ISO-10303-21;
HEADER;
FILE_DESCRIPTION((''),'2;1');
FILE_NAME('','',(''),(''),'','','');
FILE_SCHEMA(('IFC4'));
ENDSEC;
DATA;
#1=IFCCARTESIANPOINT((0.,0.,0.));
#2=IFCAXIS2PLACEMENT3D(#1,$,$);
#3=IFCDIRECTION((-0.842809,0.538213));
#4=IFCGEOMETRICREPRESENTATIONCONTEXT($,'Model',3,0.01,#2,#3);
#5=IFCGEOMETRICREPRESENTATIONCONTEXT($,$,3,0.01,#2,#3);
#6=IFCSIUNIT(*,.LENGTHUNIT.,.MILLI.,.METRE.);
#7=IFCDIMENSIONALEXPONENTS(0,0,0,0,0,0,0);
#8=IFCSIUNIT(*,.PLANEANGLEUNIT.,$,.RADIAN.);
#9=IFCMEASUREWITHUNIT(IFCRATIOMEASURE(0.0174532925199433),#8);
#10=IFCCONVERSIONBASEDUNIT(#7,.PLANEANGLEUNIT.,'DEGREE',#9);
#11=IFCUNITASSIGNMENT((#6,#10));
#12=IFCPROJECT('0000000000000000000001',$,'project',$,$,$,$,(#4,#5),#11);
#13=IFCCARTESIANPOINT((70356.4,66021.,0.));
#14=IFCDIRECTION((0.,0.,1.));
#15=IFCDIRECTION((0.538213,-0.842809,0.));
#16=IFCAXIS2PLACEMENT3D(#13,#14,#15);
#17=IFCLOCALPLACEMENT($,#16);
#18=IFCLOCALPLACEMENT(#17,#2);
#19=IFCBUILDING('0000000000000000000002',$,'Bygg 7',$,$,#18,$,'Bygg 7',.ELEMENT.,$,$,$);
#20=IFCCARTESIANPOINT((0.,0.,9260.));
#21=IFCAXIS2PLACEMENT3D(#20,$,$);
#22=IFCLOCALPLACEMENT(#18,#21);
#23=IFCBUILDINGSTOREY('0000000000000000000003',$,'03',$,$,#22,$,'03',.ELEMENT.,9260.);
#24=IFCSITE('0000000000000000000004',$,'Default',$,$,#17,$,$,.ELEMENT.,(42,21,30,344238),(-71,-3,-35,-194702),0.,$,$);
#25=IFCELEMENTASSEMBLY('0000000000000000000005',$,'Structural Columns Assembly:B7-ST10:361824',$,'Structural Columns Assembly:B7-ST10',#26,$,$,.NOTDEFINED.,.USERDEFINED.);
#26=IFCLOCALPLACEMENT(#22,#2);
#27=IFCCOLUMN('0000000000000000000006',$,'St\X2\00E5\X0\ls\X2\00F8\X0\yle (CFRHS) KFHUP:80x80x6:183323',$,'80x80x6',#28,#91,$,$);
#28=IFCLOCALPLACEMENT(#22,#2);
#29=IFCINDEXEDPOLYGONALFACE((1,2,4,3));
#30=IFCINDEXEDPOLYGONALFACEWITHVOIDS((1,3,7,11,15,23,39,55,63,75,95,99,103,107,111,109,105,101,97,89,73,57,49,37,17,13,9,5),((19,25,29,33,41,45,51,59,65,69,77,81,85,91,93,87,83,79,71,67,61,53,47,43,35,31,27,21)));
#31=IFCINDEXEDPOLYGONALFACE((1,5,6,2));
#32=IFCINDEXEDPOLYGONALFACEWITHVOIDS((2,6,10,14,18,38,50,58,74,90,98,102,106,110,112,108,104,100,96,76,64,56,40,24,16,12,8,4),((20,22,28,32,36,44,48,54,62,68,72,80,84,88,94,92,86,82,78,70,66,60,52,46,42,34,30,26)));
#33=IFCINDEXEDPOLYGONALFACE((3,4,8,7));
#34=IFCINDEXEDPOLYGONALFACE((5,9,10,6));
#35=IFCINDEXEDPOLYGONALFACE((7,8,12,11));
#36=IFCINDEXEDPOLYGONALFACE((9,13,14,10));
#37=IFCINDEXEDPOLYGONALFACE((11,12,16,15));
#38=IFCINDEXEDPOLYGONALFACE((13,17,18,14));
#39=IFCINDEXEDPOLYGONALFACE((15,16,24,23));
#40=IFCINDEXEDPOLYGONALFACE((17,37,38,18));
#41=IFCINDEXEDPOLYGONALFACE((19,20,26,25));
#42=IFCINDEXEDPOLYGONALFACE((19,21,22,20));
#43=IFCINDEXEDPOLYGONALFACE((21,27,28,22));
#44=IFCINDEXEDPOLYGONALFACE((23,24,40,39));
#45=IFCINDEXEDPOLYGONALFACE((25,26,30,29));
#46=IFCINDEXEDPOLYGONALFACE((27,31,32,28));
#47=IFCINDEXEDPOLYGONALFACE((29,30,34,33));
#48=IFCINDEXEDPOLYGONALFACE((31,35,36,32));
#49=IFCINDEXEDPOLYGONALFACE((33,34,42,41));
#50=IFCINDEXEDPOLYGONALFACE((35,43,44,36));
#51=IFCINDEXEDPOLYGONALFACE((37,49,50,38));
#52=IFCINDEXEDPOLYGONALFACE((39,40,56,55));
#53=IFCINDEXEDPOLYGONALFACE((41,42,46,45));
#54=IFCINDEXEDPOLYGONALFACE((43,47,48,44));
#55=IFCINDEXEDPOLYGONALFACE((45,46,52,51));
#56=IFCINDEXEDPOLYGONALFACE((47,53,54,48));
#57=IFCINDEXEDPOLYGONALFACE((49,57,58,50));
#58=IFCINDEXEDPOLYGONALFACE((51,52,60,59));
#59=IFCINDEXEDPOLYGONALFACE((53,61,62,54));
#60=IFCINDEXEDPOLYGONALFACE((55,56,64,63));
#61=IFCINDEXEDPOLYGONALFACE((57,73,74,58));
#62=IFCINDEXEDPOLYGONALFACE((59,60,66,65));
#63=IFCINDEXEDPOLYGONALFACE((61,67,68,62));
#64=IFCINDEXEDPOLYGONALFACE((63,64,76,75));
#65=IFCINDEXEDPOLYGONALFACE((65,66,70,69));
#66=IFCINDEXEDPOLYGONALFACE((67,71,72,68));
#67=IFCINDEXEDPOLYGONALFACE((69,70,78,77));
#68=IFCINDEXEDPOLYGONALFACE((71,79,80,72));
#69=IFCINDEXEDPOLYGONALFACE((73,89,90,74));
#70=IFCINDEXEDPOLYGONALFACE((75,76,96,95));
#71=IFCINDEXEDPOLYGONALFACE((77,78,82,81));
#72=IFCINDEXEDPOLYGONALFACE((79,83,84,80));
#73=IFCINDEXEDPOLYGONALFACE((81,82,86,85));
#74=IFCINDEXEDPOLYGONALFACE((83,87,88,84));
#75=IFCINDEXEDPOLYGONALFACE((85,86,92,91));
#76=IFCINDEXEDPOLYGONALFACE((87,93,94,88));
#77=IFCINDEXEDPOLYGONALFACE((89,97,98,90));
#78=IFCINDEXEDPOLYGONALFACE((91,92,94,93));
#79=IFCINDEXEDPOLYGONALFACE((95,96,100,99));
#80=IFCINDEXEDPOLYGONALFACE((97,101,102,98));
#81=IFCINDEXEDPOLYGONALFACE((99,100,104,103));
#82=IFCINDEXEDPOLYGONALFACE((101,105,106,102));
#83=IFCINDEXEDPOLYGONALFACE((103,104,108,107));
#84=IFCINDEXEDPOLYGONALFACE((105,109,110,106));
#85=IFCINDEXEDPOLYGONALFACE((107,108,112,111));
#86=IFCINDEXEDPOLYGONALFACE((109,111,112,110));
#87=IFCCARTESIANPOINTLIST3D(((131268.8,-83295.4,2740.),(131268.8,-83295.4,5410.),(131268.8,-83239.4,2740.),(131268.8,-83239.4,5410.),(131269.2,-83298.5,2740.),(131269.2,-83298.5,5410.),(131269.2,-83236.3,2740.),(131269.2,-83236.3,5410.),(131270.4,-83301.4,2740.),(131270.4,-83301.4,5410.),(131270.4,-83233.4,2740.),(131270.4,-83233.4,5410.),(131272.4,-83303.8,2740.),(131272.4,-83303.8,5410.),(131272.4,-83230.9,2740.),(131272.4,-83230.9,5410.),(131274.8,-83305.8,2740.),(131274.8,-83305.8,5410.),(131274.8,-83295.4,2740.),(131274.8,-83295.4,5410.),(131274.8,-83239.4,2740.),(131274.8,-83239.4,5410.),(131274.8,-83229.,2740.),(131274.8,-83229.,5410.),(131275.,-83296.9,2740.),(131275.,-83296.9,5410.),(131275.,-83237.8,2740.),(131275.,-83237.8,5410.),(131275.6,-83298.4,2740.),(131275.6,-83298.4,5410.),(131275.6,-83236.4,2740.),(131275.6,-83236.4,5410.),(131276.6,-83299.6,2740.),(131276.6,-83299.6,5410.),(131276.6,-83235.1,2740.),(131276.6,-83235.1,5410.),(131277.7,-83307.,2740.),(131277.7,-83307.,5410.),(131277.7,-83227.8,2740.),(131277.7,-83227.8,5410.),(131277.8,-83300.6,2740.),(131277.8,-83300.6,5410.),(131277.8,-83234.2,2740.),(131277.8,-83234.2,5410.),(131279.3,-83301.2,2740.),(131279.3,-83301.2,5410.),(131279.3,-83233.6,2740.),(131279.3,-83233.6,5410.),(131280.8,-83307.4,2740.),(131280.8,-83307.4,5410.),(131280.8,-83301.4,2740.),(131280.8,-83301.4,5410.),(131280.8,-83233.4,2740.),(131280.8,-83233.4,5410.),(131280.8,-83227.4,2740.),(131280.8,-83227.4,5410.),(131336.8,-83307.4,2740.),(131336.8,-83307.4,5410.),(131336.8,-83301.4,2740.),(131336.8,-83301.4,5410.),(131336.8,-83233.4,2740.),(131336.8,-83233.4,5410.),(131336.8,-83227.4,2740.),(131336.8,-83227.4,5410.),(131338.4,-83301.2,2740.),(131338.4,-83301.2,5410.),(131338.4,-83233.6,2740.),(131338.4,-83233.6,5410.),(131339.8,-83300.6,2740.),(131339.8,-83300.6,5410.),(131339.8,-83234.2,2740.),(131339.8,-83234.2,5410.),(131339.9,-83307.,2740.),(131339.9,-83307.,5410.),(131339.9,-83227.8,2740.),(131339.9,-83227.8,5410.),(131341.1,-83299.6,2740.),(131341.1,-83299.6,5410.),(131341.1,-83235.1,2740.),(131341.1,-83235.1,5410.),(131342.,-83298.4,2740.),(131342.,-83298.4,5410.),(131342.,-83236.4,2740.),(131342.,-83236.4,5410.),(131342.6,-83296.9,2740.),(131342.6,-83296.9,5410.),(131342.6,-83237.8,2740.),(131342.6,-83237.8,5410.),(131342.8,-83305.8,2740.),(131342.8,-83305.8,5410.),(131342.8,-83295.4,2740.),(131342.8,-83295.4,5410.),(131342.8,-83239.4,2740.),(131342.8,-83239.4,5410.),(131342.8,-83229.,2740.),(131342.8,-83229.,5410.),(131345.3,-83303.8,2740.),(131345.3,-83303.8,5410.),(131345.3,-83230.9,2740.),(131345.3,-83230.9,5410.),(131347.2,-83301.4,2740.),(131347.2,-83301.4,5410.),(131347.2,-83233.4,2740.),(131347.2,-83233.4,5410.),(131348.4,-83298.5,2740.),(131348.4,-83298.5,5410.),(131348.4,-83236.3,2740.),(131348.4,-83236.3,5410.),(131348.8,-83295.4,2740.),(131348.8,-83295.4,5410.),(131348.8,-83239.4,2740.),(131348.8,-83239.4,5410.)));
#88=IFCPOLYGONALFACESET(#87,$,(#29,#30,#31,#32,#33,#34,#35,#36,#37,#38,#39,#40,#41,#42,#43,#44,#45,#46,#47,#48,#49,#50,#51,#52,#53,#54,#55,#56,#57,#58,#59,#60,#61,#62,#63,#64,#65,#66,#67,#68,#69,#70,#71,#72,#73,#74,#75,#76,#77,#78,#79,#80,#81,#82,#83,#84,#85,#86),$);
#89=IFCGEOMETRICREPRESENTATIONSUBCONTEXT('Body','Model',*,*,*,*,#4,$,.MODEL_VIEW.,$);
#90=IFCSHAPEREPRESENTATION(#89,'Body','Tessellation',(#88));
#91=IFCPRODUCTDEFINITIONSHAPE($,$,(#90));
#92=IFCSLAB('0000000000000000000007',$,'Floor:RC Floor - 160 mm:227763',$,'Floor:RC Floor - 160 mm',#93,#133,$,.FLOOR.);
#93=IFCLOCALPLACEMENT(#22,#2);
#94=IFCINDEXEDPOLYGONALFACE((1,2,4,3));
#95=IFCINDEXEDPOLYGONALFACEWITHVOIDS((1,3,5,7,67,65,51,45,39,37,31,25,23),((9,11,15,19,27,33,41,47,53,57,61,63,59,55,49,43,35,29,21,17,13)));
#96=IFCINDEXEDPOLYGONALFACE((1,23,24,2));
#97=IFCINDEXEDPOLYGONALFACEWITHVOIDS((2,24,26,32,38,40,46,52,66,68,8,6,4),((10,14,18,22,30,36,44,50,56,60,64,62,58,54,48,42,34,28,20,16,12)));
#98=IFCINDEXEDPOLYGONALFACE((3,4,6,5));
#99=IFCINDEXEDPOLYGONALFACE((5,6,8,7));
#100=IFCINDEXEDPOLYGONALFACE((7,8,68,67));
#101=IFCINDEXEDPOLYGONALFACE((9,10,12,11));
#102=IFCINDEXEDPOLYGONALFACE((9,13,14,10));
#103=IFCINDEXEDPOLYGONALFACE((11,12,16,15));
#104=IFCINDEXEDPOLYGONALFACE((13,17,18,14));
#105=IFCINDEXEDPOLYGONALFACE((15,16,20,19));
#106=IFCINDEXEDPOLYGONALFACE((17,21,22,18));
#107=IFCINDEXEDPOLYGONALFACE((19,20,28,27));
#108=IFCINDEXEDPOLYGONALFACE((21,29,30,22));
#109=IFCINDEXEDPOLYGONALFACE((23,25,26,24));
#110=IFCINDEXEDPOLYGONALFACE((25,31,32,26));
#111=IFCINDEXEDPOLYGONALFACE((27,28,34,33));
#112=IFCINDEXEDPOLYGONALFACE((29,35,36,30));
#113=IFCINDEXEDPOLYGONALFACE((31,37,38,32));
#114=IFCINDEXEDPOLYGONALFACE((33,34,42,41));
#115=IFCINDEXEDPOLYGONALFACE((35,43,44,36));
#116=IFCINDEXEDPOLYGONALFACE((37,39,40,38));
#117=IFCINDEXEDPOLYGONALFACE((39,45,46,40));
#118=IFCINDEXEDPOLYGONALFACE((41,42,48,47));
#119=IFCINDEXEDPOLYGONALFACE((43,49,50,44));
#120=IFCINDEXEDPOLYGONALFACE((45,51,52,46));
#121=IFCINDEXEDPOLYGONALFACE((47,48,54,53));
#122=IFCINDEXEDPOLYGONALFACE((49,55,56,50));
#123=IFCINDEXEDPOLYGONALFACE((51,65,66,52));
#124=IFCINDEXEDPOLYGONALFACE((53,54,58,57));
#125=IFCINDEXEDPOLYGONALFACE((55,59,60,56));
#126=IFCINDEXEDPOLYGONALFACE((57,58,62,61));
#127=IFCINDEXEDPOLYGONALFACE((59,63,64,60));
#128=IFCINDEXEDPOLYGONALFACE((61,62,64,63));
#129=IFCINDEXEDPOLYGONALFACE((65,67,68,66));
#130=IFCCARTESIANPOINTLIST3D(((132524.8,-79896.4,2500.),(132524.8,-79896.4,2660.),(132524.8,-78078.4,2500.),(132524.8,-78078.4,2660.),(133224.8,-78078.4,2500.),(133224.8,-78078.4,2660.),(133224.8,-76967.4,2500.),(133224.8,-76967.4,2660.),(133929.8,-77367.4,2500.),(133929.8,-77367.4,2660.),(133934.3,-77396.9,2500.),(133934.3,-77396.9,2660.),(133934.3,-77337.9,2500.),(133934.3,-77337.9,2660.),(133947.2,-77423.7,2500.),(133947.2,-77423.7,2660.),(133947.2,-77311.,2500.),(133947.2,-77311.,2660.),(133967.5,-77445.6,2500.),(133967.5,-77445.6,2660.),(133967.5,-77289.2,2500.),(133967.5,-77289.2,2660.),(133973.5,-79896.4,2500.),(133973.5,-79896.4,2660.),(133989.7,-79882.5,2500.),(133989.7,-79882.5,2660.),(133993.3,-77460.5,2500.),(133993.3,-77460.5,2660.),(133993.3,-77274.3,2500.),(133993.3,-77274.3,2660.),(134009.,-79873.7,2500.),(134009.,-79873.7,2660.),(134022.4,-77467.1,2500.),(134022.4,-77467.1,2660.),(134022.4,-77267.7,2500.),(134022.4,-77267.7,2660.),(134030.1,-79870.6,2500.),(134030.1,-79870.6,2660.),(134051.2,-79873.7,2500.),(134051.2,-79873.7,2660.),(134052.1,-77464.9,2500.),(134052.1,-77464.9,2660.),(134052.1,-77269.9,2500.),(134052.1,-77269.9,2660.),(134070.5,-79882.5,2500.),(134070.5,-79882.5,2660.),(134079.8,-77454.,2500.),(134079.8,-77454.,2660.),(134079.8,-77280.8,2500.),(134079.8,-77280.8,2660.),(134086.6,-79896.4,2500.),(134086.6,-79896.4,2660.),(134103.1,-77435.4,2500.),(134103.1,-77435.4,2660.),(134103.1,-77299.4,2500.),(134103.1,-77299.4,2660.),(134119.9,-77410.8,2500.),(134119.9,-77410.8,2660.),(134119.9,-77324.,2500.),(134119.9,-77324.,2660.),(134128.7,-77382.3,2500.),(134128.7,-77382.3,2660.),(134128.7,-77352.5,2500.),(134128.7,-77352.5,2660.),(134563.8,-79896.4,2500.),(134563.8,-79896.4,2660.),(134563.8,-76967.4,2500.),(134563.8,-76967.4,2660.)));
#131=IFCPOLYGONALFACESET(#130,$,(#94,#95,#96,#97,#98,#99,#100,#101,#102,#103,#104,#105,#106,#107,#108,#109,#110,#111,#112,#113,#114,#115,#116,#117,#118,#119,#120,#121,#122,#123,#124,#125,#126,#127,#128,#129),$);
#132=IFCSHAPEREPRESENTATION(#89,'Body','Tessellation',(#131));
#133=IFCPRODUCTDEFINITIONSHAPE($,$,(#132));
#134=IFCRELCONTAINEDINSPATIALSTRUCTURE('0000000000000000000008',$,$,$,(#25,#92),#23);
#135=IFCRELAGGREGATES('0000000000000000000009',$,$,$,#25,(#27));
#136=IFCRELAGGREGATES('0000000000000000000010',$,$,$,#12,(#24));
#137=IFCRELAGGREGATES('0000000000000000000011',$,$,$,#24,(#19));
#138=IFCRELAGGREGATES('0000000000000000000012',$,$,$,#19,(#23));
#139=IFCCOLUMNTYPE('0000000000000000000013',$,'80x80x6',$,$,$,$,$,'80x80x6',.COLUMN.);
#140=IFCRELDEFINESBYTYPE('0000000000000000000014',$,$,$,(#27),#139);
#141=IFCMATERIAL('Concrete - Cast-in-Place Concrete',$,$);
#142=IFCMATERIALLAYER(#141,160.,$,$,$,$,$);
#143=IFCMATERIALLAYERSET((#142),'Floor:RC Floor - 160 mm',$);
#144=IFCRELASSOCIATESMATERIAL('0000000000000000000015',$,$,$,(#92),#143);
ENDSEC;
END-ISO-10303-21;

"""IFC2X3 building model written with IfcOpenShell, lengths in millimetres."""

from ifc_helpers import new_model, entity, si_unit, converted_unit, direction, frame, frame_2d, origin, place, context, subcontext, project, spatial, polyline, circle_curve, parameter, trimmed, segment, composite_curve, circle, outline, extrude, source, transform, mapped, material, layer, layer_set, layer_usage, type_object, type_shapes, element, aggregate, save


model = new_model("IFC2X3")

# Units and contexts
model_context = context("Model", 3, precision=0.01, world=origin(), true_north=direction((-0.842809, 0.538213)))
context_of_model = context(None, 3, precision=0.01, world=origin(), true_north=direction((-0.842809, 0.538213)))
body_context = subcontext(model_context, "Body", "Model", "MODEL_VIEW")
ifc_project = project(units=[si_unit("LENGTHUNIT", "METRE", prefix="MILLI"), converted_unit("PLANEANGLEUNIT", "DEGREE", entity("IfcRatioMeasure", 0.0174532925199433), si_unit("PLANEANGLEUNIT", "RADIAN"), dimensions=[0, 0, 0, 0, 0, 0, 0])], contexts=[model_context, context_of_model])

# Site, building, storey
site_placement = place(None, frame((70356.4, 66021.0, 0.0), z_axis=(0.0, 0.0, 1.0), x_axis=(0.538213, -0.842809, 0.0)))
site = spatial("IfcSite", under=ifc_project, at=site_placement, Name="Default", CompositionType="ELEMENT", RefLatitude=(42, 21, 30, 344238), RefLongitude=(-71, -3, -35, -194702), RefElevation=0.0)
building_placement = place(site_placement, origin())
building = spatial("IfcBuilding", under=site, at=building_placement, Name="Bygg 7", LongName="Bygg 7", CompositionType="ELEMENT")
storey_placement = place(building_placement, frame((0.0, 0.0, 9260.0)))
storey = spatial("IfcBuildingStorey", under=building, at=storey_placement, Name="03", LongName="03", CompositionType="ELEMENT", Elevation=9260.0)

# Element assembly, column
assembly_1_placement = place(storey_placement, origin())
assembly_1 = element("IfcElementAssembly", 1, at=assembly_1_placement, inside=storey, Name="Structural Columns Assembly:B7-ST10:361824", ObjectType="Structural Columns Assembly:B7-ST10", AssemblyPlace="NOTDEFINED", PredefinedType="USERDEFINED")
column_type_1 = type_object("IfcColumnType", Name="80x80x6", ElementType="80x80x6", PredefinedType="COLUMN")
shared_shape_1 = source(origin(), body_context, "Body", "SweptSolid", [
    extrude(outline(composite_curve([segment(trimmed(circle_curve(frame_2d((-28.0, 28.0), x_axis=(1.0, 0.0)), 12.0), [parameter(90.0)], [parameter(180.0)], True, "PARAMETER"), True, "CONTINUOUS"), segment(polyline([(-40.0, 28.0), (-40.0, -28.0)]), True, "CONTINUOUS"), segment(trimmed(circle_curve(frame_2d((-28.0, -28.0), x_axis=(1.0, 0.0)), 12.0), [parameter(180.0)], [parameter(270.0)], True, "PARAMETER"), True, "CONTINUOUS"), segment(polyline([(-28.0, -40.0), (28.0, -40.0)]), True, "CONTINUOUS"), segment(trimmed(circle_curve(frame_2d((28.0, -28.0), x_axis=(1.0, 0.0)), 12.0), [parameter(270.0)], [parameter(0.0)], True, "PARAMETER"), True, "CONTINUOUS"), segment(polyline([(40.0, -28.0), (40.0, 28.0)]), True, "CONTINUOUS"), segment(trimmed(circle_curve(frame_2d((28.0, 28.0), x_axis=(1.0, 0.0)), 12.0), [parameter(0.0)], [parameter(90.0)], True, "PARAMETER"), True, "CONTINUOUS"), segment(polyline([(28.0, 40.0), (-28.0, 40.0)]), True, "CONTINUOUS")], self_intersect=False), holes=[composite_curve([segment(polyline([(-28.0, 34.0), (28.0, 34.0)]), True, "CONTINUOUS"), segment(trimmed(circle_curve(frame_2d((28.0, 28.0), x_axis=(1.0, 0.0)), 6.0), [parameter(360.0)], [parameter(90.0)], True, "PARAMETER"), False, "CONTINUOUS"), segment(polyline([(34.0, 28.0), (34.0, -28.0)]), True, "CONTINUOUS"), segment(trimmed(circle_curve(frame_2d((28.0, -28.0), x_axis=(1.0, 0.0)), 6.0), [parameter(270.0)], [parameter(360.0)], True, "PARAMETER"), False, "CONTINUOUS"), segment(polyline([(28.0, -34.0), (-28.0, -34.0)]), True, "CONTINUOUS"), segment(trimmed(circle_curve(frame_2d((-28.0, -28.0), x_axis=(1.0, 0.0)), 6.0), [parameter(180.0)], [parameter(270.0)], True, "PARAMETER"), False, "CONTINUOUS"), segment(polyline([(-34.0, -28.0), (-34.0, 28.0)]), True, "CONTINUOUS"), segment(trimmed(circle_curve(frame_2d((-28.0, 28.0), x_axis=(1.0, 0.0)), 6.0), [parameter(90.0)], [parameter(180.0)], True, "PARAMETER"), False, "CONTINUOUS")], self_intersect=False)]), frame((41.6, 41.6, 0.0), z_axis=(0.0, 0.0, 1.0), x_axis=(0.0, -1.0, 0.0)), (0.0, 0.0, 1.0), 2670.0),
])
type_shapes(column_type_1, [shared_shape_1])
column_1_placement = place(assembly_1_placement, frame((131267.2, -83309.0, 2740.0)))
column_1 = element("IfcColumn", 2, at=column_1_placement, type_object=column_type_1, Name="Stålsøyle (CFRHS) KFHUP:80x80x6:183323", ObjectType="80x80x6", context=body_context, shape_type="MappedRepresentation", body=[
    mapped(shared_shape_1, transform((0.0, 0.0, 0.0), scale=1.0)),
])
aggregate(assembly_1, [column_1])

# Slab, openings
ifc_material_1 = material(Name="Concrete - Cast-in-Place Concrete")
ifc_layer_1 = layer(ifc_material_1, 160.0)
ifc_layer_set_1 = layer_set([ifc_layer_1], Name="Floor:RC Floor - 160 mm")
ifc_layer_usage_1 = layer_usage(ifc_layer_set_1, "AXIS3", "POSITIVE", 0.0)
slab_1_placement = place(storey_placement, frame((132524.8, -79896.4, 2500.0)))
slab_1 = element("IfcSlab", 3, at=slab_1_placement, inside=storey, material=ifc_layer_usage_1, Name="Floor:RC Floor - 160 mm:227763", ObjectType="Floor:RC Floor - 160 mm", PredefinedType="FLOOR", context=body_context, shape_type="SweptSolid", body=[
    extrude(outline(polyline([(1019.5, 353.5), (319.5, 353.5), (319.5, 1464.5), (-1019.5, 1464.5), (-1019.5, -1464.5), (1019.5, -1464.5), (1019.5, 353.5)])), frame((1019.5, 1464.5, 160.0), z_axis=(0.0, 0.0, -1.0), x_axis=(-1.0, 0.0, 0.0)), (0.0, 0.0, 1.0), 160.0),
])
opening_1_placement = place(storey_placement, frame((132524.8, -79896.4, 2500.0)))
element("IfcOpeningElement", 4, at=opening_1_placement, cuts=slab_1, ObjectType="Opening", context=body_context, shape_type="SweptSolid", body=[
    extrude(circle(Radius=75.0, at=frame_2d((-485.8, -1513.8), x_axis=(1.0, 0.0))), frame((1019.5, 1464.5, 160.0), z_axis=(0.0, 0.0, -1.0), x_axis=(-1.0, 0.0, 0.0)), (0.0, 0.0, 1.0), 160.0),
])
opening_2_placement = place(storey_placement, frame((132524.8, -79896.4, 2500.0)))
element("IfcOpeningElement", 5, at=opening_2_placement, cuts=slab_1, ObjectType="Opening", context=body_context, shape_type="SweptSolid", body=[
    extrude(circle(Radius=100.0, at=frame_2d((-485.5, 1064.5), x_axis=(1.0, 0.0))), frame((1019.5, 1464.5, 160.0), z_axis=(0.0, 0.0, -1.0), x_axis=(-1.0, 0.0, 0.0)), (0.0, 0.0, 1.0), 160.0),
])

save(model, "model.ifc")
